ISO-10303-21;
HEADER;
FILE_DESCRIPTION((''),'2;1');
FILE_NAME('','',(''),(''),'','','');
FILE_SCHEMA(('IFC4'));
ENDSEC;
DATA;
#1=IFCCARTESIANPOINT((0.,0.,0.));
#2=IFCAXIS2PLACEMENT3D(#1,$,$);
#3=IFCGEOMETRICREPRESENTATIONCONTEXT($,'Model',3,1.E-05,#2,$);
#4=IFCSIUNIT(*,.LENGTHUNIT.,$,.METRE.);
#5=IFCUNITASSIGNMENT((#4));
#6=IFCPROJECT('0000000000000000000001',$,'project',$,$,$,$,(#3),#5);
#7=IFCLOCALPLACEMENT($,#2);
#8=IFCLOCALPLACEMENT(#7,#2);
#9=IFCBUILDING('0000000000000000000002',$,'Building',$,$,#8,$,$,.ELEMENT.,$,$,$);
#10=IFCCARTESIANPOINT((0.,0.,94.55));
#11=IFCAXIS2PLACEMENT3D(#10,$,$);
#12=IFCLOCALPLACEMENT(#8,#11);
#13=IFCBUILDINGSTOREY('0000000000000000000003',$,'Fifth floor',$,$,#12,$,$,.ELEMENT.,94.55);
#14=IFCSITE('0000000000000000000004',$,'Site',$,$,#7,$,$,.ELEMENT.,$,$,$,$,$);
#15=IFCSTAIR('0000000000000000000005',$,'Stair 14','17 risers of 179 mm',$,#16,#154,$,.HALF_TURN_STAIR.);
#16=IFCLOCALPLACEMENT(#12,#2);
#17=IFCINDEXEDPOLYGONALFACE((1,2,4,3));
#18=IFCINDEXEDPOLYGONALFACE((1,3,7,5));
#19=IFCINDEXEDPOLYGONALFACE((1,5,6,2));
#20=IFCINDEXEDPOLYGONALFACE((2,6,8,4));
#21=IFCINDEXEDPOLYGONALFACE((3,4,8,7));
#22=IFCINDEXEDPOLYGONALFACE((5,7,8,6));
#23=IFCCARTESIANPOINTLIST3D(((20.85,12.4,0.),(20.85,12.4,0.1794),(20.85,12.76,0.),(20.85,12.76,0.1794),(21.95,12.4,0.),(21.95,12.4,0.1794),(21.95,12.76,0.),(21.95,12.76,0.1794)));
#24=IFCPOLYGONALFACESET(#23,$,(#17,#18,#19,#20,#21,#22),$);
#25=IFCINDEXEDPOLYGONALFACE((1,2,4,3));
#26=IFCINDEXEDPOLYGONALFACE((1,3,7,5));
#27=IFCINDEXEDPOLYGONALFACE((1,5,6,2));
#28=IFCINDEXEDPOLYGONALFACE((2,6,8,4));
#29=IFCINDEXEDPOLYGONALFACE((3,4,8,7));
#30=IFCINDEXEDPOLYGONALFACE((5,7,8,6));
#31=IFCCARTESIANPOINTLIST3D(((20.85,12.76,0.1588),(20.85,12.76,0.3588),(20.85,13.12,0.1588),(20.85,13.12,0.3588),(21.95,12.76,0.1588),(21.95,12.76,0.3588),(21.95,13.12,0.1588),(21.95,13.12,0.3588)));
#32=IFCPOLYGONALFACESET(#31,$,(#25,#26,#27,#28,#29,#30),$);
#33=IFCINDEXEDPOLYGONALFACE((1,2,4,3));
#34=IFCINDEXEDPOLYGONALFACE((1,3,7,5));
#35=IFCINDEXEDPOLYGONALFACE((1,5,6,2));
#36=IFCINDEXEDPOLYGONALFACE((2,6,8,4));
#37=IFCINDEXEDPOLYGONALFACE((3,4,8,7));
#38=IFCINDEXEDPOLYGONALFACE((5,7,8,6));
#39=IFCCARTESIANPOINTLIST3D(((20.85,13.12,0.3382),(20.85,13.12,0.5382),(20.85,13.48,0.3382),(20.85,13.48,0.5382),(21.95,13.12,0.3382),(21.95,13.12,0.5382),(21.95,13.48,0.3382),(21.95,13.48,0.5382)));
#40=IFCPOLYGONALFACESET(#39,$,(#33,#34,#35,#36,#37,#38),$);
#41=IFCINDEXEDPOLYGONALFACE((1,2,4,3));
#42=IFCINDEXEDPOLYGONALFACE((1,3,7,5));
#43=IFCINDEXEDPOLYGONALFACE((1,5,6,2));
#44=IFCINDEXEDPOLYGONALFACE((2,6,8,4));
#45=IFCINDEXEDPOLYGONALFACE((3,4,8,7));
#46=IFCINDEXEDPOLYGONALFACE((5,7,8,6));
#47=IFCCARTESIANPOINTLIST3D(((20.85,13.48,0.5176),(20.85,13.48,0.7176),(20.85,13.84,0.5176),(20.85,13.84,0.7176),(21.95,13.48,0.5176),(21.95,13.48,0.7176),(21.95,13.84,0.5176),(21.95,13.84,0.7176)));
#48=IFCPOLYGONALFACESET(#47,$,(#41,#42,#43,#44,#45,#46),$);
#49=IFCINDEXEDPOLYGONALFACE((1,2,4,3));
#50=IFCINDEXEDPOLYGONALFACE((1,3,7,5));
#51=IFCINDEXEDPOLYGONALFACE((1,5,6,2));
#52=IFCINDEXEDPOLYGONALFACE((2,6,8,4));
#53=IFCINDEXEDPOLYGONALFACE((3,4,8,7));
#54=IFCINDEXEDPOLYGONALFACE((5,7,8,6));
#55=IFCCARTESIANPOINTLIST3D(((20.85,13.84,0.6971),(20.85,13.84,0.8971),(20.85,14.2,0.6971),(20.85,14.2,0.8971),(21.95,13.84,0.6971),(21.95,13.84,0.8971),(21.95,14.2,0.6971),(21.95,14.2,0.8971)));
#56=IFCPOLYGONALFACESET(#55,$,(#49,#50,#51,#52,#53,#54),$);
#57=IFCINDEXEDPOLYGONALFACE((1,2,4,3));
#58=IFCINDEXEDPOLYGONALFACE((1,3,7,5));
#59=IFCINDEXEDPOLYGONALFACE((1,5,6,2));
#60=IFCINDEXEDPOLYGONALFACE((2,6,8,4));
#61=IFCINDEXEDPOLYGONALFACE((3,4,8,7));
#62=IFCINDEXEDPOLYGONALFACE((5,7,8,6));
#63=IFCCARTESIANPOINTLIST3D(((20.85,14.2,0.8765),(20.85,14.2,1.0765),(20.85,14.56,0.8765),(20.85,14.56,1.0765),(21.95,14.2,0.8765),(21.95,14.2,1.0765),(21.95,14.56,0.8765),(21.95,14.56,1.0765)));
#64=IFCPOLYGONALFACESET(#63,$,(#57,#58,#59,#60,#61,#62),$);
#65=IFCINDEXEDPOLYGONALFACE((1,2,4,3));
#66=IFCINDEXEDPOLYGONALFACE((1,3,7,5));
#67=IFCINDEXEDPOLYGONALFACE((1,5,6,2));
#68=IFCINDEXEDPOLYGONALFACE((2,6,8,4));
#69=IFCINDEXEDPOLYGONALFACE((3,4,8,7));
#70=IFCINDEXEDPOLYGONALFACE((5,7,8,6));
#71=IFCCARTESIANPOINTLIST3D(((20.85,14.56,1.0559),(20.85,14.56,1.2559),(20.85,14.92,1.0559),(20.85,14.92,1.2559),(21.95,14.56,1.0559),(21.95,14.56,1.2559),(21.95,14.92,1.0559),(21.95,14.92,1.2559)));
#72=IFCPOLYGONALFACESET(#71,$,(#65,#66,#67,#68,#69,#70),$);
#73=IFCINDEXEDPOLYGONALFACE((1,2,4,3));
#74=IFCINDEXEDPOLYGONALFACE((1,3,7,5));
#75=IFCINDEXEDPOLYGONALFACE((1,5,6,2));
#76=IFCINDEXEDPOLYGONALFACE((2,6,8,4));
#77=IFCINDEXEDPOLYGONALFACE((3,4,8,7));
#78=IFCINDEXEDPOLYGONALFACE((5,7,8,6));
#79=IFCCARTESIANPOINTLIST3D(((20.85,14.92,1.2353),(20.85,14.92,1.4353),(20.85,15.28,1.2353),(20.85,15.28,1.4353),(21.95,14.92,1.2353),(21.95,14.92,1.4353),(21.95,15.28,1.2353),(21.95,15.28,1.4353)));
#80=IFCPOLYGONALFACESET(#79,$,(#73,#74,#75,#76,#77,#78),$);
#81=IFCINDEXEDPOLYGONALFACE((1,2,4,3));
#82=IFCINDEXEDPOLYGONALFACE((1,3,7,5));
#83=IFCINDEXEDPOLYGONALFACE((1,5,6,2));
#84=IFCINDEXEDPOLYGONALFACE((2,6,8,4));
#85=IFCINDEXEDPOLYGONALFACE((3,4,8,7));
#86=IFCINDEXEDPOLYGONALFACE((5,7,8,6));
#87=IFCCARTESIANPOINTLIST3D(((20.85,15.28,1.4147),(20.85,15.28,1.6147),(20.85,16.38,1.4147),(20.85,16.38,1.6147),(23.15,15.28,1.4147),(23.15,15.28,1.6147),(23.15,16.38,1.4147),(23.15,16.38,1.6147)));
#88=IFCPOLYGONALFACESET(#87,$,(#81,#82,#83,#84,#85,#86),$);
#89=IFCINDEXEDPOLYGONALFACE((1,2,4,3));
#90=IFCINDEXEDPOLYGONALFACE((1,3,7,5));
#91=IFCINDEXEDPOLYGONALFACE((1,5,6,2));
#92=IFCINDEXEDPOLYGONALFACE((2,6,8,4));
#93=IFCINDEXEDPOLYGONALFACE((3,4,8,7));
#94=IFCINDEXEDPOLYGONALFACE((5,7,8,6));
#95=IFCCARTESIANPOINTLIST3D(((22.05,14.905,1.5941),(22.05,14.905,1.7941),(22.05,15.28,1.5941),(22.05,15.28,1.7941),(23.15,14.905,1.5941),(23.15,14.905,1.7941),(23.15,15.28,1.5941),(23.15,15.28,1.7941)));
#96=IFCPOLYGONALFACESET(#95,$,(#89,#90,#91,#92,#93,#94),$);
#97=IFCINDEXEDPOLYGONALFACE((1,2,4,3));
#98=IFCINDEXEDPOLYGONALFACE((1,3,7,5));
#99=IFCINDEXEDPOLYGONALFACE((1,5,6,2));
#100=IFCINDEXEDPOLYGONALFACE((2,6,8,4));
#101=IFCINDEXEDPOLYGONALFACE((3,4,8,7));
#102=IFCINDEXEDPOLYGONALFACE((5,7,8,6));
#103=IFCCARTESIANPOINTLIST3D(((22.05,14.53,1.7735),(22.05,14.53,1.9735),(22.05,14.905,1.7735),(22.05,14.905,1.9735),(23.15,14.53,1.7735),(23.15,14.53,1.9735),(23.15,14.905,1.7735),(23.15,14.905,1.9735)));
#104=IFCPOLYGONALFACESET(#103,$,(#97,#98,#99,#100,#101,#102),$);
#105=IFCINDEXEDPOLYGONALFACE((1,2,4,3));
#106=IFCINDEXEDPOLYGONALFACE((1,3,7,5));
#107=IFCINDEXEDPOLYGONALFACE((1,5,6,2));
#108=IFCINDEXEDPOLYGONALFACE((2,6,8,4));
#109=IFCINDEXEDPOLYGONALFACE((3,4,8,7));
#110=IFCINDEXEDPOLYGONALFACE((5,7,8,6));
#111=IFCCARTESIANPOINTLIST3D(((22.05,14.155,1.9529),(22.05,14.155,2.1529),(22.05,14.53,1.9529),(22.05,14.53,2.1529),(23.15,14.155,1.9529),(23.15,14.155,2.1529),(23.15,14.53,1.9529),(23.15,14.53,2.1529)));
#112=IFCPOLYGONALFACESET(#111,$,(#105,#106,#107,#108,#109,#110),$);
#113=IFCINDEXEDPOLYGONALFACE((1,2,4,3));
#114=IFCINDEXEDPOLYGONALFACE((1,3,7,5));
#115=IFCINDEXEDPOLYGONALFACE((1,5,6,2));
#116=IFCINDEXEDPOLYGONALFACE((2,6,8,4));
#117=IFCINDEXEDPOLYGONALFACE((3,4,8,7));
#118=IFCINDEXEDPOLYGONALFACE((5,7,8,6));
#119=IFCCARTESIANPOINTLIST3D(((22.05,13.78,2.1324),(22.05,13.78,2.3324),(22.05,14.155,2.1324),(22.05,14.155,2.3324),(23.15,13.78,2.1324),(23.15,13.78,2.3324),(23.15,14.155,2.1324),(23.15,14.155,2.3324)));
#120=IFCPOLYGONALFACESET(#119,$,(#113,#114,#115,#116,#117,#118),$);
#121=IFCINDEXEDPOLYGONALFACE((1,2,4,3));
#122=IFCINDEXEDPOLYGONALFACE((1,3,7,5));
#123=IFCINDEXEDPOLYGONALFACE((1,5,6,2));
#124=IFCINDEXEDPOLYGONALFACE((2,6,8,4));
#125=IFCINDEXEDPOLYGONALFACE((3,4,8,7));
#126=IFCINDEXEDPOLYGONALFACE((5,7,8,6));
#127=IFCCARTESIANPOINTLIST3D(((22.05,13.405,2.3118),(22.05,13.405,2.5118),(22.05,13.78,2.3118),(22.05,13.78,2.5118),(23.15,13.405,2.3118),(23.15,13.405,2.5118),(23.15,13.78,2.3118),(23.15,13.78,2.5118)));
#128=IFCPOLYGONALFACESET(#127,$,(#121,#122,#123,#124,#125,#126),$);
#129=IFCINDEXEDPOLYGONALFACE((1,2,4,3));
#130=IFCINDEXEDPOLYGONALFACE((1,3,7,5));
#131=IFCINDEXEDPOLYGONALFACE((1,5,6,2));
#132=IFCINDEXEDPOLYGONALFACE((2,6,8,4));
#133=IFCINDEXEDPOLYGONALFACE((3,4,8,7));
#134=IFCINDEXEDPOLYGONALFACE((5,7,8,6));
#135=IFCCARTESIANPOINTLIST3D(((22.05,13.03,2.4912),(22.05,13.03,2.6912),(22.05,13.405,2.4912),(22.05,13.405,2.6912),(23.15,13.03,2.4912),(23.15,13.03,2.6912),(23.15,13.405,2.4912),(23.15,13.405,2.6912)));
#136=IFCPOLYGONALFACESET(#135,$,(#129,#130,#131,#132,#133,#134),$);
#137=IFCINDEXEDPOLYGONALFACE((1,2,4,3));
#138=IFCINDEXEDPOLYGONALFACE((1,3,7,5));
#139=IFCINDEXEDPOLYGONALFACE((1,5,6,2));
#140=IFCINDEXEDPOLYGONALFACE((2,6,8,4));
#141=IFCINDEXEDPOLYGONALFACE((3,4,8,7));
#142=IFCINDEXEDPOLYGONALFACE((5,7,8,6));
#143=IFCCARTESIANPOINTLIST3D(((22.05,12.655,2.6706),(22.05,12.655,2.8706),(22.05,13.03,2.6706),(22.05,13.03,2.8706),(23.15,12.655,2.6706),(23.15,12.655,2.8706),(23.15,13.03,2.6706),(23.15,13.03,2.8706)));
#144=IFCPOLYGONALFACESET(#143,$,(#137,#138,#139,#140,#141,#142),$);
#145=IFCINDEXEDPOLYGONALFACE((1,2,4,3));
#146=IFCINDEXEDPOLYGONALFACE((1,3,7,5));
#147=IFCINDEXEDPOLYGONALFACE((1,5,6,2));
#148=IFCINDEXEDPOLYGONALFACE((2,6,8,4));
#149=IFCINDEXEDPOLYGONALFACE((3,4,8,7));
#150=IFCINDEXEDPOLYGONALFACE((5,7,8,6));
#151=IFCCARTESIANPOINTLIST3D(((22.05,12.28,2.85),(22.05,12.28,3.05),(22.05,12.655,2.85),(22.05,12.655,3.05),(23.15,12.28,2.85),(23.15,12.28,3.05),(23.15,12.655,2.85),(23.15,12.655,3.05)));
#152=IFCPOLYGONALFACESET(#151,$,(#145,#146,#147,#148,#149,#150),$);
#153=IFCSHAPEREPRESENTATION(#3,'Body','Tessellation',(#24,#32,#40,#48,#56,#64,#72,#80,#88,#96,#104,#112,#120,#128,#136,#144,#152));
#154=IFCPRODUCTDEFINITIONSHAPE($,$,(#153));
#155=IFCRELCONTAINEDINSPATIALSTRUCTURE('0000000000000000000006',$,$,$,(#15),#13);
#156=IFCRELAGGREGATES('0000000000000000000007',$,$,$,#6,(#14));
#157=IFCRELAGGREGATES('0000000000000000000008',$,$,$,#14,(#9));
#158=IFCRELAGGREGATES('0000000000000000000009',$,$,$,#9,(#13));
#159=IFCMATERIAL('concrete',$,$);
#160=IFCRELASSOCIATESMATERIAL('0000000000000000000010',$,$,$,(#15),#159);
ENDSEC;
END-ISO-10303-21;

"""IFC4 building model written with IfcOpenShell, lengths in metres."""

from ifc_helpers import new_model, si_unit, frame, origin, place, context, project, spatial, polyline, outline, extrude, material, element, save


model = new_model("IFC4")

# Units and contexts
model_context = context("Model", 3, precision=1e-05, world=origin())
ifc_project = project(units=[si_unit("LENGTHUNIT", "METRE")], contexts=[model_context])

# Site, building, storey
site_placement = place(None, origin())
site = spatial("IfcSite", under=ifc_project, at=site_placement, Name="Site", CompositionType="ELEMENT")
building_placement = place(site_placement, origin())
building = spatial("IfcBuilding", under=site, at=building_placement, Name="Building", CompositionType="ELEMENT")
storey_placement = place(building_placement, frame((0.0, 0.0, 94.55)))
storey = spatial("IfcBuildingStorey", under=building, at=storey_placement, Name="Fifth floor", CompositionType="ELEMENT", Elevation=94.55)

# Shared definitions
ifc_material = material(Name="concrete")

# Stair
stair_1_placement = place(storey_placement, frame((21.4, 12.4, 0.0), z_axis=(0.0, 0.0, 1.0), x_axis=(0.0, 1.0, 0.0)))
element("IfcStair", 1, at=stair_1_placement, inside=storey, material=ifc_material, Name="Stair 14", Description="17 risers of 179 mm", PredefinedType="HALF_TURN_STAIR", context=model_context, shape_type="SweptSolid", body=[
    extrude(outline(polyline([(0.0, -0.55), (0.36, -0.55), (0.36, 0.55), (0.0, 0.55), (0.0, -0.55)])), origin(), (0.0, 0.0, 1.0), 0.1794),
    extrude(outline(polyline([(0.36, -0.55), (0.72, -0.55), (0.72, 0.55), (0.36, 0.55), (0.36, -0.55)])), frame((0.0, 0.0, 0.1588)), (0.0, 0.0, 1.0), 0.2),
    extrude(outline(polyline([(0.72, -0.55), (1.08, -0.55), (1.08, 0.55), (0.72, 0.55), (0.72, -0.55)])), frame((0.0, 0.0, 0.3382)), (0.0, 0.0, 1.0), 0.2),
    extrude(outline(polyline([(1.08, -0.55), (1.44, -0.55), (1.44, 0.55), (1.08, 0.55), (1.08, -0.55)])), frame((0.0, 0.0, 0.5176)), (0.0, 0.0, 1.0), 0.2),
    extrude(outline(polyline([(1.44, -0.55), (1.8, -0.55), (1.8, 0.55), (1.44, 0.55), (1.44, -0.55)])), frame((0.0, 0.0, 0.6971)), (0.0, 0.0, 1.0), 0.2),
    extrude(outline(polyline([(1.8, -0.55), (2.16, -0.55), (2.16, 0.55), (1.8, 0.55), (1.8, -0.55)])), frame((0.0, 0.0, 0.8765)), (0.0, 0.0, 1.0), 0.2),
    extrude(outline(polyline([(2.16, -0.55), (2.52, -0.55), (2.52, 0.55), (2.16, 0.55), (2.16, -0.55)])), frame((0.0, 0.0, 1.0559)), (0.0, 0.0, 1.0), 0.2),
    extrude(outline(polyline([(2.52, -0.55), (2.88, -0.55), (2.88, 0.55), (2.52, 0.55), (2.52, -0.55)])), frame((0.0, 0.0, 1.2353)), (0.0, 0.0, 1.0), 0.2),
    extrude(outline(polyline([(2.88, -1.75), (3.98, -1.75), (3.98, 0.55), (2.88, 0.55), (2.88, -1.75)])), frame((0.0, 0.0, 1.4147)), (0.0, 0.0, 1.0), 0.2),
    extrude(outline(polyline([(2.505, -1.75), (2.88, -1.75), (2.88, -0.65), (2.505, -0.65), (2.505, -1.75)])), frame((0.0, 0.0, 1.5941)), (0.0, 0.0, 1.0), 0.2),
    extrude(outline(polyline([(2.13, -1.75), (2.505, -1.75), (2.505, -0.65), (2.13, -0.65), (2.13, -1.75)])), frame((0.0, 0.0, 1.7735)), (0.0, 0.0, 1.0), 0.2),
    extrude(outline(polyline([(1.755, -1.75), (2.13, -1.75), (2.13, -0.65), (1.755, -0.65), (1.755, -1.75)])), frame((0.0, 0.0, 1.9529)), (0.0, 0.0, 1.0), 0.2),
    extrude(outline(polyline([(1.38, -1.75), (1.755, -1.75), (1.755, -0.65), (1.38, -0.65), (1.38, -1.75)])), frame((0.0, 0.0, 2.1324)), (0.0, 0.0, 1.0), 0.2),
    extrude(outline(polyline([(1.005, -1.75), (1.38, -1.75), (1.38, -0.65), (1.005, -0.65), (1.005, -1.75)])), frame((0.0, 0.0, 2.3118)), (0.0, 0.0, 1.0), 0.2),
    extrude(outline(polyline([(0.63, -1.75), (1.005, -1.75), (1.005, -0.65), (0.63, -0.65), (0.63, -1.75)])), frame((0.0, 0.0, 2.4912)), (0.0, 0.0, 1.0), 0.2),
    extrude(outline(polyline([(0.255, -1.75), (0.63, -1.75), (0.63, -0.65), (0.255, -0.65), (0.255, -1.75)])), frame((0.0, 0.0, 2.6706)), (0.0, 0.0, 1.0), 0.2),
    extrude(outline(polyline([(-0.12, -1.75), (0.255, -1.75), (0.255, -0.65), (-0.12, -0.65), (-0.12, -1.75)])), frame((0.0, 0.0, 2.85)), (0.0, 0.0, 1.0), 0.2),
])

save(model, "model.ifc")
